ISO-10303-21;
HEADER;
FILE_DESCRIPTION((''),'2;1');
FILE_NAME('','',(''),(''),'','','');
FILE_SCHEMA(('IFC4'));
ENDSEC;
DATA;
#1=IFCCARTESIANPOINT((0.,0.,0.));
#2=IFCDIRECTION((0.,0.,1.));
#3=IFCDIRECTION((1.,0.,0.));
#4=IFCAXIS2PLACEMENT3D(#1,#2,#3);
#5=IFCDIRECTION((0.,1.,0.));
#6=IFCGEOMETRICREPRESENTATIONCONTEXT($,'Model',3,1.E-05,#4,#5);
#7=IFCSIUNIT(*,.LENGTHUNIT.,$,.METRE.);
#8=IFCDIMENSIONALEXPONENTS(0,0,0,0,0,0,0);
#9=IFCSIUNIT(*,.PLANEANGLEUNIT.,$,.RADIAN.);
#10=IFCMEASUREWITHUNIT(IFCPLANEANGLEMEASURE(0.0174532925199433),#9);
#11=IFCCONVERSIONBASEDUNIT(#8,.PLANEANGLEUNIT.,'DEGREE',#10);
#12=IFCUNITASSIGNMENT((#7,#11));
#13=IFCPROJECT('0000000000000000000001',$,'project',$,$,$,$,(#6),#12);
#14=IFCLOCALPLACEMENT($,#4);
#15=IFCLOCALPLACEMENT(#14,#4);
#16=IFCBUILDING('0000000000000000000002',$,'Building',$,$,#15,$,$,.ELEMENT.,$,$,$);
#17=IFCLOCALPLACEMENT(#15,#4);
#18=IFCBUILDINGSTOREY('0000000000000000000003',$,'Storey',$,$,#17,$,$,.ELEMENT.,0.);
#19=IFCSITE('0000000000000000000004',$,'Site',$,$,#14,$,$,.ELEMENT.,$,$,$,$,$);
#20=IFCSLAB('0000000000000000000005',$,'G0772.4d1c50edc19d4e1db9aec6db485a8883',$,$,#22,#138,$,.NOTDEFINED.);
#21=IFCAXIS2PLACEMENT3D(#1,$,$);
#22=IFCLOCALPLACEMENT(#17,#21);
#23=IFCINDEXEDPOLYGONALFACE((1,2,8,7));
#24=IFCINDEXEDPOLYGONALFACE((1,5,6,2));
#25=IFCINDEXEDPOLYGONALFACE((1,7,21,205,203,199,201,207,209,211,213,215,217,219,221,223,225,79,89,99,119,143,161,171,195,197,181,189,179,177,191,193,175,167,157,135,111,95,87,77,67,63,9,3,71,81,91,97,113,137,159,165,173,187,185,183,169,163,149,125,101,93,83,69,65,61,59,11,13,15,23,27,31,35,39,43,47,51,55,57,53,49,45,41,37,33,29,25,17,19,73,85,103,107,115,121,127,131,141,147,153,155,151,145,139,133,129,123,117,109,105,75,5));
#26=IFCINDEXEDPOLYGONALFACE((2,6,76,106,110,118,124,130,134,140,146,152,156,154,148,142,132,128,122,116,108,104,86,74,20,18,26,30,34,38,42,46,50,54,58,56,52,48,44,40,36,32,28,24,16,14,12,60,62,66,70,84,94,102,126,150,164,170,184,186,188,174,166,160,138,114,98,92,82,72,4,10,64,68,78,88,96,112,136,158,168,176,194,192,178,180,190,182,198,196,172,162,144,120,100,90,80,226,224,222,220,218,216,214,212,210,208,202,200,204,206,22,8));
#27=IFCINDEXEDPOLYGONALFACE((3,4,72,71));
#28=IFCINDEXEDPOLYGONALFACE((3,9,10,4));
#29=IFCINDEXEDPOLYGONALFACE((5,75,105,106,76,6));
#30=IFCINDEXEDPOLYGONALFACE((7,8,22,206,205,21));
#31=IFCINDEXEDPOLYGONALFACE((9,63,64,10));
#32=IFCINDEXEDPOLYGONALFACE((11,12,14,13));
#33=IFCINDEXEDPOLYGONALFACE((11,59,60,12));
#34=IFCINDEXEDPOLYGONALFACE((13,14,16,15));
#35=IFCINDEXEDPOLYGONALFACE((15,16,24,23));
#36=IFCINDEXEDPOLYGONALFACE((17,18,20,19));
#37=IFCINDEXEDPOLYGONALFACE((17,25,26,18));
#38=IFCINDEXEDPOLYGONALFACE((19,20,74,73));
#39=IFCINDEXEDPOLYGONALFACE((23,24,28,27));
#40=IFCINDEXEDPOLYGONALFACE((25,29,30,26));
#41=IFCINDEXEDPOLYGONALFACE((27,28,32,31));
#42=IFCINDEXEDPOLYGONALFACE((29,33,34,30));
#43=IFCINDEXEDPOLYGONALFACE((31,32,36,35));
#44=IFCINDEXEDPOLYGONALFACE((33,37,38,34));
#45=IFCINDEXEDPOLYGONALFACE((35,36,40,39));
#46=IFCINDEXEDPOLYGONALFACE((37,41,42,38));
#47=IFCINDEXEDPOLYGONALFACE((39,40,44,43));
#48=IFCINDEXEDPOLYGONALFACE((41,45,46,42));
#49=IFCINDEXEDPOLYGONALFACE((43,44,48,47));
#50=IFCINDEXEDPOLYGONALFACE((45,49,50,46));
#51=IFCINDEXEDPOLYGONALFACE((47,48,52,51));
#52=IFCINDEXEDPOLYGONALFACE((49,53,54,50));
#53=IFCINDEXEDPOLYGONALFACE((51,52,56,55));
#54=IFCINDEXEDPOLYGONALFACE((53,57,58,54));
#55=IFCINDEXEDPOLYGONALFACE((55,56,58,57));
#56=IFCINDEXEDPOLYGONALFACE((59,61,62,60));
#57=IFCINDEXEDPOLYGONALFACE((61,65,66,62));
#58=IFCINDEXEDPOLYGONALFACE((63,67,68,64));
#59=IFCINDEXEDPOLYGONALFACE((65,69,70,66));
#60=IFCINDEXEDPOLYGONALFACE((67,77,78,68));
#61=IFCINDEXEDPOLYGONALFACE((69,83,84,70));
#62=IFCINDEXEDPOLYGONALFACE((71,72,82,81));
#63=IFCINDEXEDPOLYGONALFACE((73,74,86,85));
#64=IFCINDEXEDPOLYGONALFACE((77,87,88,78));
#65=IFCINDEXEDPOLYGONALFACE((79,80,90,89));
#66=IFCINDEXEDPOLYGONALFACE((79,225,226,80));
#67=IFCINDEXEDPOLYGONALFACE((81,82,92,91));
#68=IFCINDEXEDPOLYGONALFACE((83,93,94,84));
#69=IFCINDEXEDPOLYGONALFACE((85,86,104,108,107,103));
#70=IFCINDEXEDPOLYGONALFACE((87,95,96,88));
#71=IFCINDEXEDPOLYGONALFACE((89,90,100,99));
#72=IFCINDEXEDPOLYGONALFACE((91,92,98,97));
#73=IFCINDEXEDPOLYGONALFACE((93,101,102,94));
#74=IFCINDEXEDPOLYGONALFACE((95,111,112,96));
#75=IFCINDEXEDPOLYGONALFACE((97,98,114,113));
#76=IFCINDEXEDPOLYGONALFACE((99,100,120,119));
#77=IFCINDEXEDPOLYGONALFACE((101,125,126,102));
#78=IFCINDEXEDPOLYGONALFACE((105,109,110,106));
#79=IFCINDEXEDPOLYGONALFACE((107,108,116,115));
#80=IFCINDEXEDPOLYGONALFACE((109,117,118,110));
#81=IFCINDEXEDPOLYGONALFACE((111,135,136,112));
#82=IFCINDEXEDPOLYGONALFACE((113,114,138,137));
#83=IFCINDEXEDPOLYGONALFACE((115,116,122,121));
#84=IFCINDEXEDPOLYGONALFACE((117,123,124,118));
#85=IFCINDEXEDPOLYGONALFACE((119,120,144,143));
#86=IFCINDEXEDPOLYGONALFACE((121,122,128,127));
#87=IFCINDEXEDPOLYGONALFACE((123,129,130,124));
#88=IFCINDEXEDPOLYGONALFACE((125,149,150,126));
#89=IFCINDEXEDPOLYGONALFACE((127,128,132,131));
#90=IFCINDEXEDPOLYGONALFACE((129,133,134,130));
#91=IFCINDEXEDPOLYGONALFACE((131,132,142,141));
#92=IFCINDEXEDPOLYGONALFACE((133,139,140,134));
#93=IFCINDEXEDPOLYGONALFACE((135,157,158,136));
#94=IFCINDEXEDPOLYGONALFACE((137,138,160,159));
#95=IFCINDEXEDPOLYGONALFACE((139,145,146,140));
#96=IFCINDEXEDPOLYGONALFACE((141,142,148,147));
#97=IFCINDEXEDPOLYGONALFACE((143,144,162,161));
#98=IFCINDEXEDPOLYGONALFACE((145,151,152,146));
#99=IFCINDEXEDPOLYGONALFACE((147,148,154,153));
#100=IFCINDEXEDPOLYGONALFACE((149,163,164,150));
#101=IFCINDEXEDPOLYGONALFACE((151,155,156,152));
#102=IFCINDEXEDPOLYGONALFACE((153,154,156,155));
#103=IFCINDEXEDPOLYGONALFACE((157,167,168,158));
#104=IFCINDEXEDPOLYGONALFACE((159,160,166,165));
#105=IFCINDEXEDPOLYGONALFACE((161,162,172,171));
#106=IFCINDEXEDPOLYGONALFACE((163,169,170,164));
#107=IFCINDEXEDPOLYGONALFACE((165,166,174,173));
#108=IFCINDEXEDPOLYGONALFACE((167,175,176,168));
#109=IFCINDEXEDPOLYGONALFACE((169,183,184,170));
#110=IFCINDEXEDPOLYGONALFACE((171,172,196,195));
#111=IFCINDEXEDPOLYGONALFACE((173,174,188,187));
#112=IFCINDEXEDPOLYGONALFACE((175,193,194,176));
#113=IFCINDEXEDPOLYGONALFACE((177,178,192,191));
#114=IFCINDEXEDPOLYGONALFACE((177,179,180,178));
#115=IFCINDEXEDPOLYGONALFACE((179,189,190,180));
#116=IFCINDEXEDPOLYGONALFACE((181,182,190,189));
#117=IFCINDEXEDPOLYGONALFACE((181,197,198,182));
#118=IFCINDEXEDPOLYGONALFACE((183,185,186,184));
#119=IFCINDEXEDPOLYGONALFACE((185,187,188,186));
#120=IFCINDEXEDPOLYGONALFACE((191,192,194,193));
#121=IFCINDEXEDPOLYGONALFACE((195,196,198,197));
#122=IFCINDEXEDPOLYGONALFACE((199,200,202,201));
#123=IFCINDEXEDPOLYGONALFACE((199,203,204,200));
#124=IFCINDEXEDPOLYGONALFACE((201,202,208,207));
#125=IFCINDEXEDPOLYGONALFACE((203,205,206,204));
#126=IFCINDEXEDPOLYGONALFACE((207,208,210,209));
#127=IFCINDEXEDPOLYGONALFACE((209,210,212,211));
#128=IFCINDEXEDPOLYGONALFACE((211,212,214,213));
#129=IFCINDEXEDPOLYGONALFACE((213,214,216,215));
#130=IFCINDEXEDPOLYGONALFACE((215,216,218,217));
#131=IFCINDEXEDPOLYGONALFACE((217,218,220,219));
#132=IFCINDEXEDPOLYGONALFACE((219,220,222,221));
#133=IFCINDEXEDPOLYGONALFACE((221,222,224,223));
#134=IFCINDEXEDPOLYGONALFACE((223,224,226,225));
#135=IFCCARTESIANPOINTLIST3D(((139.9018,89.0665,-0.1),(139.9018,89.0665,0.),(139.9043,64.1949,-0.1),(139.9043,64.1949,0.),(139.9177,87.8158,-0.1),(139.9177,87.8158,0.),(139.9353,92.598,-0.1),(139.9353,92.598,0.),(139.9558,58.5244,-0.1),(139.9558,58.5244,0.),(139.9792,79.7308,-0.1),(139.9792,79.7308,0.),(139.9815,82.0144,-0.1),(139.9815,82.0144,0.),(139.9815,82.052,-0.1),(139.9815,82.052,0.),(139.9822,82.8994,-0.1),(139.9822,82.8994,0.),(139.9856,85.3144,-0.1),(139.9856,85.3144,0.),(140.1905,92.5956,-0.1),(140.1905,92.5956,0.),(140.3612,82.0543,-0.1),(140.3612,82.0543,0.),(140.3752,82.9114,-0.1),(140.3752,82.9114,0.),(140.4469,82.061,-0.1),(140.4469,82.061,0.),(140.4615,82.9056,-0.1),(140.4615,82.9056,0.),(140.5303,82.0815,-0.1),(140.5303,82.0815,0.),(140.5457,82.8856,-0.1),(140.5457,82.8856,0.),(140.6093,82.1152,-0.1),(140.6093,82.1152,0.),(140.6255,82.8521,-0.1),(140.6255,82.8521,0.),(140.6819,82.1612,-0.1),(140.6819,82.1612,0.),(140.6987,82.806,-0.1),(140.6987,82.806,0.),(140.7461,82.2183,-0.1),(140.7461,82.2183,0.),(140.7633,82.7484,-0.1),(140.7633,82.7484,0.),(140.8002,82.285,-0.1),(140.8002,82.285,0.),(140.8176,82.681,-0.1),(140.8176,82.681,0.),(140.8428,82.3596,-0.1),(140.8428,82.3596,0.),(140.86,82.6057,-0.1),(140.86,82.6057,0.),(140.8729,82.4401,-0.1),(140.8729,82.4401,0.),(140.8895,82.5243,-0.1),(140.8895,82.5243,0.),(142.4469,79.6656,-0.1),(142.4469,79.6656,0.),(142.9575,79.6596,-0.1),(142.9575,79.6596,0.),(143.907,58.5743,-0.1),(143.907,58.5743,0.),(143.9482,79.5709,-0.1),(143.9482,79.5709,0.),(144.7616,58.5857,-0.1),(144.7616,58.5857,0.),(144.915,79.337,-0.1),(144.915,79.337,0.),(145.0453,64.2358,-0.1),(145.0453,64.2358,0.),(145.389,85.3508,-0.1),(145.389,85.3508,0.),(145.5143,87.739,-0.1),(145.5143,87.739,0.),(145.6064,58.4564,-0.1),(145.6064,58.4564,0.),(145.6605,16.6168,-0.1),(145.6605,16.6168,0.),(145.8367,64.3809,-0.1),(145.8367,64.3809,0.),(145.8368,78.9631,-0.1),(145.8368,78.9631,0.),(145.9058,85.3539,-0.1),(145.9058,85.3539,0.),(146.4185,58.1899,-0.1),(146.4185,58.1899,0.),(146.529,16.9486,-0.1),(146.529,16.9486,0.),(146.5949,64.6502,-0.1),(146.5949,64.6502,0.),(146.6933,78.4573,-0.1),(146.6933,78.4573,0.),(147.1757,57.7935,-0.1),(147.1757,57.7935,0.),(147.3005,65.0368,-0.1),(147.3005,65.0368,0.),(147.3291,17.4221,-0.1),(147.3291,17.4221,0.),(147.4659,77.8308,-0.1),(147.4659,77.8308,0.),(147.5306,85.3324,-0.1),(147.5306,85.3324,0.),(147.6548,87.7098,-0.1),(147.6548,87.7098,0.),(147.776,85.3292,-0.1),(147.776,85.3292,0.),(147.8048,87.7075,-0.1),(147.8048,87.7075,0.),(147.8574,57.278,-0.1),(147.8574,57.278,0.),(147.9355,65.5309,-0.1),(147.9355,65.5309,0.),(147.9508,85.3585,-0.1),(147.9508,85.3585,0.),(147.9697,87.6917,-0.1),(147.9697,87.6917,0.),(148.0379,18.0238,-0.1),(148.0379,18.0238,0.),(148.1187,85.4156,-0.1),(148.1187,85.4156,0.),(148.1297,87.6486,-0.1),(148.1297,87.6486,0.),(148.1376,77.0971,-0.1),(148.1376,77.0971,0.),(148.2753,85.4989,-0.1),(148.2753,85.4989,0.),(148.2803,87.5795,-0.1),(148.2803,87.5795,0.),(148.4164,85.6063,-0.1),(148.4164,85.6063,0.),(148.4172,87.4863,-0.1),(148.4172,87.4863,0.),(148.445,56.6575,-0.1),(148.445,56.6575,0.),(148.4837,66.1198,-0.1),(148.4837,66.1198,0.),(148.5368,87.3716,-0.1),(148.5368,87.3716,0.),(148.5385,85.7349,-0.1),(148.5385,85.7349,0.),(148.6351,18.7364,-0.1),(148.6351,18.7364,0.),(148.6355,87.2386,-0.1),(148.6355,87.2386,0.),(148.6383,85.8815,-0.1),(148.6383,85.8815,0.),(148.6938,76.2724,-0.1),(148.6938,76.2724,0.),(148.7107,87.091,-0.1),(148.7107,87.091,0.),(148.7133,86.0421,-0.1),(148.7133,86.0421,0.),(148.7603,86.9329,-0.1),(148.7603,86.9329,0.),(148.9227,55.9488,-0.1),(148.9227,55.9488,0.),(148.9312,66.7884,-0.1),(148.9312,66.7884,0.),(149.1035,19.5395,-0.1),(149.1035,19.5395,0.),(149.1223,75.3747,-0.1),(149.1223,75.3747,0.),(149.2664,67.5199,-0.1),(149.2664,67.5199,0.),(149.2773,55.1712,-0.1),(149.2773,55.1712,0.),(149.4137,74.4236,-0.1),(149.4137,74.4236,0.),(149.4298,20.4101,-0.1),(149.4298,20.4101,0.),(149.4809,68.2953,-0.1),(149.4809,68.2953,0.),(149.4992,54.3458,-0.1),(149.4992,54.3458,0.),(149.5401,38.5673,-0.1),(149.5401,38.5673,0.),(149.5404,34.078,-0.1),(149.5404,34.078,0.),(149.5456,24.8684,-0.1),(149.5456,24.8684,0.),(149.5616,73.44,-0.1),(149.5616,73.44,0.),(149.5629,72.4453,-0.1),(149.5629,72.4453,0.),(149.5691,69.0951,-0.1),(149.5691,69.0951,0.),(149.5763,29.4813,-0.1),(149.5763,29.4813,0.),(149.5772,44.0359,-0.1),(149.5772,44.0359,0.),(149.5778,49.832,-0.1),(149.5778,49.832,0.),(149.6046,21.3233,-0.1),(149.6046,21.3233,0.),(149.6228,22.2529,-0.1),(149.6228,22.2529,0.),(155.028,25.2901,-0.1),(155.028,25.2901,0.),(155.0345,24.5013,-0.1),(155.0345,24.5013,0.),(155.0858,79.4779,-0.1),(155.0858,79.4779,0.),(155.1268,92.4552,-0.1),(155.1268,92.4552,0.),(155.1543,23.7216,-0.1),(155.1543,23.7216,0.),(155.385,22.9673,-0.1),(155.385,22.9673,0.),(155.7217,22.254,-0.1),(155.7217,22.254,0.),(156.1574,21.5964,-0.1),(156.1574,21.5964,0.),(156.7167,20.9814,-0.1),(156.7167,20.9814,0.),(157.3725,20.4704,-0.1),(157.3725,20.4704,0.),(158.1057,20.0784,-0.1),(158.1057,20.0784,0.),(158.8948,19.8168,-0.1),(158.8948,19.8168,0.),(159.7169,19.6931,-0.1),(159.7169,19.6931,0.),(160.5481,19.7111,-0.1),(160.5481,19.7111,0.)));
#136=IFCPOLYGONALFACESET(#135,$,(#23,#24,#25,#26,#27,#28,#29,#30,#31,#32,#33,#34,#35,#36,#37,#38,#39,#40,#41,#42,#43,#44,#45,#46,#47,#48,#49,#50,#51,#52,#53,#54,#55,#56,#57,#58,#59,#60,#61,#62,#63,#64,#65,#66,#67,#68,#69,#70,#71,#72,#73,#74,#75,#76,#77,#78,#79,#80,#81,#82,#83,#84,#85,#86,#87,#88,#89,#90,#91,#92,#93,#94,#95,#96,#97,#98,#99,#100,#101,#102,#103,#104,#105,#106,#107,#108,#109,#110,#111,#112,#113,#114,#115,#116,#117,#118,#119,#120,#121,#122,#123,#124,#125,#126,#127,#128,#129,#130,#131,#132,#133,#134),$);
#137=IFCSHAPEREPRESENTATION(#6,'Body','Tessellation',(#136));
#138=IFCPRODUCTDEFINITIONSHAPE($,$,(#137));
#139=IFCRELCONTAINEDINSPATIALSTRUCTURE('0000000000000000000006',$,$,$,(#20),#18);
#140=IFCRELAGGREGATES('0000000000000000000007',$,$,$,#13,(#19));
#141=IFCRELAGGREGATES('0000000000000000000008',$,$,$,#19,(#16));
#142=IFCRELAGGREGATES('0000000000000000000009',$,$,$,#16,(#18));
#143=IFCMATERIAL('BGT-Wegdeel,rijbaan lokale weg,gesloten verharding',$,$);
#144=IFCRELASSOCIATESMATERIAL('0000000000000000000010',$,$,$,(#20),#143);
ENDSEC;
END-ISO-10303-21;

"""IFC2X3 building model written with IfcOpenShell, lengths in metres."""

from ifc_helpers import new_model, entity, si_unit, converted_unit, direction, frame, origin_with_axes, place, context, project, spatial, polyline, outline, extrude, material, element, save


model = new_model("IFC2X3")

# Units and contexts
model_context = context("Model", 3, precision=1e-05, world=origin_with_axes(), true_north=direction((0.0, 1.0, 0.0)))
ifc_project = project(units=[si_unit("LENGTHUNIT", "METRE"), converted_unit("PLANEANGLEUNIT", "DEGREE", entity("IfcPlaneAngleMeasure", 0.0174532925199433), si_unit("PLANEANGLEUNIT", "RADIAN"), dimensions=[0, 0, 0, 0, 0, 0, 0])], contexts=[model_context])

# Site, building, storey
site_placement = place(None, origin_with_axes())
site = spatial("IfcSite", under=ifc_project, at=site_placement, Name="Site", CompositionType="ELEMENT")
building_placement = place(site_placement, origin_with_axes())
building = spatial("IfcBuilding", under=site, at=building_placement, Name="Building", CompositionType="ELEMENT")
storey_placement = place(building_placement, origin_with_axes())
storey = spatial("IfcBuildingStorey", under=building, at=storey_placement, Name="Storey", CompositionType="ELEMENT", Elevation=0.0)

# Slab
ifc_material_1 = material(Name="BGT-Wegdeel,rijbaan lokale weg,gesloten verharding")
slab_1_placement = place(storey_placement, frame((0.0, 0.0, -0.1), z_axis=(0.0, 0.0, 1.0), x_axis=(1.0, 0.0, 0.0)))
element("IfcSlab", 1, at=slab_1_placement, inside=storey, material=ifc_material_1, Name="G0772.4d1c50edc19d4e1db9aec6db485a8883", PredefinedType="NOTDEFINED", context=model_context, shape_type="SweptSolid", body=[
    extrude(outline(polyline([(155.028, 25.2901), (155.0345, 24.5013), (155.1543, 23.7216), (155.385, 22.9673), (155.7217, 22.254), (156.1574, 21.5964), (156.7167, 20.9814), (157.3725, 20.4704), (158.1057, 20.0784), (158.8948, 19.8168), (159.7169, 19.6931), (160.5481, 19.7111), (145.6605, 16.6168), (146.529, 16.9486), (147.3291, 17.4221), (148.0379, 18.0238), (148.6351, 18.7364), (149.1035, 19.5395), (149.4298, 20.4101), (149.6046, 21.3233), (149.6228, 22.2529), (149.5456, 24.8684), (149.5763, 29.4813), (149.5404, 34.078), (149.5401, 38.5673), (149.5772, 44.0359), (149.5778, 49.832), (149.4992, 54.3458), (149.2773, 55.1712), (148.9227, 55.9488), (148.445, 56.6575), (147.8574, 57.278), (147.1757, 57.7935), (146.4185, 58.1899), (145.6064, 58.4564), (144.7616, 58.5857), (143.907, 58.5743), (139.9558, 58.5244), (139.9043, 64.1949), (145.0453, 64.2358), (145.8367, 64.3809), (146.5949, 64.6502), (147.3005, 65.0368), (147.9355, 65.5309), (148.4837, 66.1198), (148.9312, 66.7884), (149.2664, 67.5199), (149.4809, 68.2953), (149.5691, 69.0951), (149.5629, 72.4453), (149.5616, 73.44), (149.4137, 74.4236), (149.1223, 75.3747), (148.6938, 76.2724), (148.1376, 77.0971), (147.4659, 77.8308), (146.6933, 78.4573), (145.8368, 78.9631), (144.915, 79.337), (143.9482, 79.5709), (142.9575, 79.6596), (142.4469, 79.6656), (139.9792, 79.7308), (139.9815, 82.0144), (139.9815, 82.052), (140.3612, 82.0543), (140.4469, 82.061), (140.5303, 82.0815), (140.6093, 82.1152), (140.6819, 82.1612), (140.7461, 82.2183), (140.8002, 82.285), (140.8428, 82.3596), (140.8729, 82.4401), (140.8895, 82.5243), (140.86, 82.6057), (140.8176, 82.681), (140.7633, 82.7484), (140.6987, 82.806), (140.6255, 82.8521), (140.5457, 82.8856), (140.4615, 82.9056), (140.3752, 82.9114), (139.9822, 82.8994), (139.9856, 85.3144), (145.389, 85.3508), (145.9058, 85.3539), (147.5306, 85.3324), (147.776, 85.3292), (147.9508, 85.3585), (148.1187, 85.4156), (148.2753, 85.4989), (148.4164, 85.6063), (148.5385, 85.7349), (148.6383, 85.8815), (148.7133, 86.0421), (148.7603, 86.9329), (148.7107, 87.091), (148.6355, 87.2386), (148.5368, 87.3716), (148.4172, 87.4863), (148.2803, 87.5795), (148.1297, 87.6486), (147.9697, 87.6917), (147.8048, 87.7075), (147.6548, 87.7098), (145.5143, 87.739), (139.9177, 87.8158), (139.9018, 89.0665), (139.9353, 92.598), (140.1905, 92.5956), (155.1268, 92.4552), (155.0858, 79.4779), (155.028, 25.2901)])), origin_with_axes(), (0.0, 0.0, 1.0), 0.1),
])

save(model, "model.ifc")
